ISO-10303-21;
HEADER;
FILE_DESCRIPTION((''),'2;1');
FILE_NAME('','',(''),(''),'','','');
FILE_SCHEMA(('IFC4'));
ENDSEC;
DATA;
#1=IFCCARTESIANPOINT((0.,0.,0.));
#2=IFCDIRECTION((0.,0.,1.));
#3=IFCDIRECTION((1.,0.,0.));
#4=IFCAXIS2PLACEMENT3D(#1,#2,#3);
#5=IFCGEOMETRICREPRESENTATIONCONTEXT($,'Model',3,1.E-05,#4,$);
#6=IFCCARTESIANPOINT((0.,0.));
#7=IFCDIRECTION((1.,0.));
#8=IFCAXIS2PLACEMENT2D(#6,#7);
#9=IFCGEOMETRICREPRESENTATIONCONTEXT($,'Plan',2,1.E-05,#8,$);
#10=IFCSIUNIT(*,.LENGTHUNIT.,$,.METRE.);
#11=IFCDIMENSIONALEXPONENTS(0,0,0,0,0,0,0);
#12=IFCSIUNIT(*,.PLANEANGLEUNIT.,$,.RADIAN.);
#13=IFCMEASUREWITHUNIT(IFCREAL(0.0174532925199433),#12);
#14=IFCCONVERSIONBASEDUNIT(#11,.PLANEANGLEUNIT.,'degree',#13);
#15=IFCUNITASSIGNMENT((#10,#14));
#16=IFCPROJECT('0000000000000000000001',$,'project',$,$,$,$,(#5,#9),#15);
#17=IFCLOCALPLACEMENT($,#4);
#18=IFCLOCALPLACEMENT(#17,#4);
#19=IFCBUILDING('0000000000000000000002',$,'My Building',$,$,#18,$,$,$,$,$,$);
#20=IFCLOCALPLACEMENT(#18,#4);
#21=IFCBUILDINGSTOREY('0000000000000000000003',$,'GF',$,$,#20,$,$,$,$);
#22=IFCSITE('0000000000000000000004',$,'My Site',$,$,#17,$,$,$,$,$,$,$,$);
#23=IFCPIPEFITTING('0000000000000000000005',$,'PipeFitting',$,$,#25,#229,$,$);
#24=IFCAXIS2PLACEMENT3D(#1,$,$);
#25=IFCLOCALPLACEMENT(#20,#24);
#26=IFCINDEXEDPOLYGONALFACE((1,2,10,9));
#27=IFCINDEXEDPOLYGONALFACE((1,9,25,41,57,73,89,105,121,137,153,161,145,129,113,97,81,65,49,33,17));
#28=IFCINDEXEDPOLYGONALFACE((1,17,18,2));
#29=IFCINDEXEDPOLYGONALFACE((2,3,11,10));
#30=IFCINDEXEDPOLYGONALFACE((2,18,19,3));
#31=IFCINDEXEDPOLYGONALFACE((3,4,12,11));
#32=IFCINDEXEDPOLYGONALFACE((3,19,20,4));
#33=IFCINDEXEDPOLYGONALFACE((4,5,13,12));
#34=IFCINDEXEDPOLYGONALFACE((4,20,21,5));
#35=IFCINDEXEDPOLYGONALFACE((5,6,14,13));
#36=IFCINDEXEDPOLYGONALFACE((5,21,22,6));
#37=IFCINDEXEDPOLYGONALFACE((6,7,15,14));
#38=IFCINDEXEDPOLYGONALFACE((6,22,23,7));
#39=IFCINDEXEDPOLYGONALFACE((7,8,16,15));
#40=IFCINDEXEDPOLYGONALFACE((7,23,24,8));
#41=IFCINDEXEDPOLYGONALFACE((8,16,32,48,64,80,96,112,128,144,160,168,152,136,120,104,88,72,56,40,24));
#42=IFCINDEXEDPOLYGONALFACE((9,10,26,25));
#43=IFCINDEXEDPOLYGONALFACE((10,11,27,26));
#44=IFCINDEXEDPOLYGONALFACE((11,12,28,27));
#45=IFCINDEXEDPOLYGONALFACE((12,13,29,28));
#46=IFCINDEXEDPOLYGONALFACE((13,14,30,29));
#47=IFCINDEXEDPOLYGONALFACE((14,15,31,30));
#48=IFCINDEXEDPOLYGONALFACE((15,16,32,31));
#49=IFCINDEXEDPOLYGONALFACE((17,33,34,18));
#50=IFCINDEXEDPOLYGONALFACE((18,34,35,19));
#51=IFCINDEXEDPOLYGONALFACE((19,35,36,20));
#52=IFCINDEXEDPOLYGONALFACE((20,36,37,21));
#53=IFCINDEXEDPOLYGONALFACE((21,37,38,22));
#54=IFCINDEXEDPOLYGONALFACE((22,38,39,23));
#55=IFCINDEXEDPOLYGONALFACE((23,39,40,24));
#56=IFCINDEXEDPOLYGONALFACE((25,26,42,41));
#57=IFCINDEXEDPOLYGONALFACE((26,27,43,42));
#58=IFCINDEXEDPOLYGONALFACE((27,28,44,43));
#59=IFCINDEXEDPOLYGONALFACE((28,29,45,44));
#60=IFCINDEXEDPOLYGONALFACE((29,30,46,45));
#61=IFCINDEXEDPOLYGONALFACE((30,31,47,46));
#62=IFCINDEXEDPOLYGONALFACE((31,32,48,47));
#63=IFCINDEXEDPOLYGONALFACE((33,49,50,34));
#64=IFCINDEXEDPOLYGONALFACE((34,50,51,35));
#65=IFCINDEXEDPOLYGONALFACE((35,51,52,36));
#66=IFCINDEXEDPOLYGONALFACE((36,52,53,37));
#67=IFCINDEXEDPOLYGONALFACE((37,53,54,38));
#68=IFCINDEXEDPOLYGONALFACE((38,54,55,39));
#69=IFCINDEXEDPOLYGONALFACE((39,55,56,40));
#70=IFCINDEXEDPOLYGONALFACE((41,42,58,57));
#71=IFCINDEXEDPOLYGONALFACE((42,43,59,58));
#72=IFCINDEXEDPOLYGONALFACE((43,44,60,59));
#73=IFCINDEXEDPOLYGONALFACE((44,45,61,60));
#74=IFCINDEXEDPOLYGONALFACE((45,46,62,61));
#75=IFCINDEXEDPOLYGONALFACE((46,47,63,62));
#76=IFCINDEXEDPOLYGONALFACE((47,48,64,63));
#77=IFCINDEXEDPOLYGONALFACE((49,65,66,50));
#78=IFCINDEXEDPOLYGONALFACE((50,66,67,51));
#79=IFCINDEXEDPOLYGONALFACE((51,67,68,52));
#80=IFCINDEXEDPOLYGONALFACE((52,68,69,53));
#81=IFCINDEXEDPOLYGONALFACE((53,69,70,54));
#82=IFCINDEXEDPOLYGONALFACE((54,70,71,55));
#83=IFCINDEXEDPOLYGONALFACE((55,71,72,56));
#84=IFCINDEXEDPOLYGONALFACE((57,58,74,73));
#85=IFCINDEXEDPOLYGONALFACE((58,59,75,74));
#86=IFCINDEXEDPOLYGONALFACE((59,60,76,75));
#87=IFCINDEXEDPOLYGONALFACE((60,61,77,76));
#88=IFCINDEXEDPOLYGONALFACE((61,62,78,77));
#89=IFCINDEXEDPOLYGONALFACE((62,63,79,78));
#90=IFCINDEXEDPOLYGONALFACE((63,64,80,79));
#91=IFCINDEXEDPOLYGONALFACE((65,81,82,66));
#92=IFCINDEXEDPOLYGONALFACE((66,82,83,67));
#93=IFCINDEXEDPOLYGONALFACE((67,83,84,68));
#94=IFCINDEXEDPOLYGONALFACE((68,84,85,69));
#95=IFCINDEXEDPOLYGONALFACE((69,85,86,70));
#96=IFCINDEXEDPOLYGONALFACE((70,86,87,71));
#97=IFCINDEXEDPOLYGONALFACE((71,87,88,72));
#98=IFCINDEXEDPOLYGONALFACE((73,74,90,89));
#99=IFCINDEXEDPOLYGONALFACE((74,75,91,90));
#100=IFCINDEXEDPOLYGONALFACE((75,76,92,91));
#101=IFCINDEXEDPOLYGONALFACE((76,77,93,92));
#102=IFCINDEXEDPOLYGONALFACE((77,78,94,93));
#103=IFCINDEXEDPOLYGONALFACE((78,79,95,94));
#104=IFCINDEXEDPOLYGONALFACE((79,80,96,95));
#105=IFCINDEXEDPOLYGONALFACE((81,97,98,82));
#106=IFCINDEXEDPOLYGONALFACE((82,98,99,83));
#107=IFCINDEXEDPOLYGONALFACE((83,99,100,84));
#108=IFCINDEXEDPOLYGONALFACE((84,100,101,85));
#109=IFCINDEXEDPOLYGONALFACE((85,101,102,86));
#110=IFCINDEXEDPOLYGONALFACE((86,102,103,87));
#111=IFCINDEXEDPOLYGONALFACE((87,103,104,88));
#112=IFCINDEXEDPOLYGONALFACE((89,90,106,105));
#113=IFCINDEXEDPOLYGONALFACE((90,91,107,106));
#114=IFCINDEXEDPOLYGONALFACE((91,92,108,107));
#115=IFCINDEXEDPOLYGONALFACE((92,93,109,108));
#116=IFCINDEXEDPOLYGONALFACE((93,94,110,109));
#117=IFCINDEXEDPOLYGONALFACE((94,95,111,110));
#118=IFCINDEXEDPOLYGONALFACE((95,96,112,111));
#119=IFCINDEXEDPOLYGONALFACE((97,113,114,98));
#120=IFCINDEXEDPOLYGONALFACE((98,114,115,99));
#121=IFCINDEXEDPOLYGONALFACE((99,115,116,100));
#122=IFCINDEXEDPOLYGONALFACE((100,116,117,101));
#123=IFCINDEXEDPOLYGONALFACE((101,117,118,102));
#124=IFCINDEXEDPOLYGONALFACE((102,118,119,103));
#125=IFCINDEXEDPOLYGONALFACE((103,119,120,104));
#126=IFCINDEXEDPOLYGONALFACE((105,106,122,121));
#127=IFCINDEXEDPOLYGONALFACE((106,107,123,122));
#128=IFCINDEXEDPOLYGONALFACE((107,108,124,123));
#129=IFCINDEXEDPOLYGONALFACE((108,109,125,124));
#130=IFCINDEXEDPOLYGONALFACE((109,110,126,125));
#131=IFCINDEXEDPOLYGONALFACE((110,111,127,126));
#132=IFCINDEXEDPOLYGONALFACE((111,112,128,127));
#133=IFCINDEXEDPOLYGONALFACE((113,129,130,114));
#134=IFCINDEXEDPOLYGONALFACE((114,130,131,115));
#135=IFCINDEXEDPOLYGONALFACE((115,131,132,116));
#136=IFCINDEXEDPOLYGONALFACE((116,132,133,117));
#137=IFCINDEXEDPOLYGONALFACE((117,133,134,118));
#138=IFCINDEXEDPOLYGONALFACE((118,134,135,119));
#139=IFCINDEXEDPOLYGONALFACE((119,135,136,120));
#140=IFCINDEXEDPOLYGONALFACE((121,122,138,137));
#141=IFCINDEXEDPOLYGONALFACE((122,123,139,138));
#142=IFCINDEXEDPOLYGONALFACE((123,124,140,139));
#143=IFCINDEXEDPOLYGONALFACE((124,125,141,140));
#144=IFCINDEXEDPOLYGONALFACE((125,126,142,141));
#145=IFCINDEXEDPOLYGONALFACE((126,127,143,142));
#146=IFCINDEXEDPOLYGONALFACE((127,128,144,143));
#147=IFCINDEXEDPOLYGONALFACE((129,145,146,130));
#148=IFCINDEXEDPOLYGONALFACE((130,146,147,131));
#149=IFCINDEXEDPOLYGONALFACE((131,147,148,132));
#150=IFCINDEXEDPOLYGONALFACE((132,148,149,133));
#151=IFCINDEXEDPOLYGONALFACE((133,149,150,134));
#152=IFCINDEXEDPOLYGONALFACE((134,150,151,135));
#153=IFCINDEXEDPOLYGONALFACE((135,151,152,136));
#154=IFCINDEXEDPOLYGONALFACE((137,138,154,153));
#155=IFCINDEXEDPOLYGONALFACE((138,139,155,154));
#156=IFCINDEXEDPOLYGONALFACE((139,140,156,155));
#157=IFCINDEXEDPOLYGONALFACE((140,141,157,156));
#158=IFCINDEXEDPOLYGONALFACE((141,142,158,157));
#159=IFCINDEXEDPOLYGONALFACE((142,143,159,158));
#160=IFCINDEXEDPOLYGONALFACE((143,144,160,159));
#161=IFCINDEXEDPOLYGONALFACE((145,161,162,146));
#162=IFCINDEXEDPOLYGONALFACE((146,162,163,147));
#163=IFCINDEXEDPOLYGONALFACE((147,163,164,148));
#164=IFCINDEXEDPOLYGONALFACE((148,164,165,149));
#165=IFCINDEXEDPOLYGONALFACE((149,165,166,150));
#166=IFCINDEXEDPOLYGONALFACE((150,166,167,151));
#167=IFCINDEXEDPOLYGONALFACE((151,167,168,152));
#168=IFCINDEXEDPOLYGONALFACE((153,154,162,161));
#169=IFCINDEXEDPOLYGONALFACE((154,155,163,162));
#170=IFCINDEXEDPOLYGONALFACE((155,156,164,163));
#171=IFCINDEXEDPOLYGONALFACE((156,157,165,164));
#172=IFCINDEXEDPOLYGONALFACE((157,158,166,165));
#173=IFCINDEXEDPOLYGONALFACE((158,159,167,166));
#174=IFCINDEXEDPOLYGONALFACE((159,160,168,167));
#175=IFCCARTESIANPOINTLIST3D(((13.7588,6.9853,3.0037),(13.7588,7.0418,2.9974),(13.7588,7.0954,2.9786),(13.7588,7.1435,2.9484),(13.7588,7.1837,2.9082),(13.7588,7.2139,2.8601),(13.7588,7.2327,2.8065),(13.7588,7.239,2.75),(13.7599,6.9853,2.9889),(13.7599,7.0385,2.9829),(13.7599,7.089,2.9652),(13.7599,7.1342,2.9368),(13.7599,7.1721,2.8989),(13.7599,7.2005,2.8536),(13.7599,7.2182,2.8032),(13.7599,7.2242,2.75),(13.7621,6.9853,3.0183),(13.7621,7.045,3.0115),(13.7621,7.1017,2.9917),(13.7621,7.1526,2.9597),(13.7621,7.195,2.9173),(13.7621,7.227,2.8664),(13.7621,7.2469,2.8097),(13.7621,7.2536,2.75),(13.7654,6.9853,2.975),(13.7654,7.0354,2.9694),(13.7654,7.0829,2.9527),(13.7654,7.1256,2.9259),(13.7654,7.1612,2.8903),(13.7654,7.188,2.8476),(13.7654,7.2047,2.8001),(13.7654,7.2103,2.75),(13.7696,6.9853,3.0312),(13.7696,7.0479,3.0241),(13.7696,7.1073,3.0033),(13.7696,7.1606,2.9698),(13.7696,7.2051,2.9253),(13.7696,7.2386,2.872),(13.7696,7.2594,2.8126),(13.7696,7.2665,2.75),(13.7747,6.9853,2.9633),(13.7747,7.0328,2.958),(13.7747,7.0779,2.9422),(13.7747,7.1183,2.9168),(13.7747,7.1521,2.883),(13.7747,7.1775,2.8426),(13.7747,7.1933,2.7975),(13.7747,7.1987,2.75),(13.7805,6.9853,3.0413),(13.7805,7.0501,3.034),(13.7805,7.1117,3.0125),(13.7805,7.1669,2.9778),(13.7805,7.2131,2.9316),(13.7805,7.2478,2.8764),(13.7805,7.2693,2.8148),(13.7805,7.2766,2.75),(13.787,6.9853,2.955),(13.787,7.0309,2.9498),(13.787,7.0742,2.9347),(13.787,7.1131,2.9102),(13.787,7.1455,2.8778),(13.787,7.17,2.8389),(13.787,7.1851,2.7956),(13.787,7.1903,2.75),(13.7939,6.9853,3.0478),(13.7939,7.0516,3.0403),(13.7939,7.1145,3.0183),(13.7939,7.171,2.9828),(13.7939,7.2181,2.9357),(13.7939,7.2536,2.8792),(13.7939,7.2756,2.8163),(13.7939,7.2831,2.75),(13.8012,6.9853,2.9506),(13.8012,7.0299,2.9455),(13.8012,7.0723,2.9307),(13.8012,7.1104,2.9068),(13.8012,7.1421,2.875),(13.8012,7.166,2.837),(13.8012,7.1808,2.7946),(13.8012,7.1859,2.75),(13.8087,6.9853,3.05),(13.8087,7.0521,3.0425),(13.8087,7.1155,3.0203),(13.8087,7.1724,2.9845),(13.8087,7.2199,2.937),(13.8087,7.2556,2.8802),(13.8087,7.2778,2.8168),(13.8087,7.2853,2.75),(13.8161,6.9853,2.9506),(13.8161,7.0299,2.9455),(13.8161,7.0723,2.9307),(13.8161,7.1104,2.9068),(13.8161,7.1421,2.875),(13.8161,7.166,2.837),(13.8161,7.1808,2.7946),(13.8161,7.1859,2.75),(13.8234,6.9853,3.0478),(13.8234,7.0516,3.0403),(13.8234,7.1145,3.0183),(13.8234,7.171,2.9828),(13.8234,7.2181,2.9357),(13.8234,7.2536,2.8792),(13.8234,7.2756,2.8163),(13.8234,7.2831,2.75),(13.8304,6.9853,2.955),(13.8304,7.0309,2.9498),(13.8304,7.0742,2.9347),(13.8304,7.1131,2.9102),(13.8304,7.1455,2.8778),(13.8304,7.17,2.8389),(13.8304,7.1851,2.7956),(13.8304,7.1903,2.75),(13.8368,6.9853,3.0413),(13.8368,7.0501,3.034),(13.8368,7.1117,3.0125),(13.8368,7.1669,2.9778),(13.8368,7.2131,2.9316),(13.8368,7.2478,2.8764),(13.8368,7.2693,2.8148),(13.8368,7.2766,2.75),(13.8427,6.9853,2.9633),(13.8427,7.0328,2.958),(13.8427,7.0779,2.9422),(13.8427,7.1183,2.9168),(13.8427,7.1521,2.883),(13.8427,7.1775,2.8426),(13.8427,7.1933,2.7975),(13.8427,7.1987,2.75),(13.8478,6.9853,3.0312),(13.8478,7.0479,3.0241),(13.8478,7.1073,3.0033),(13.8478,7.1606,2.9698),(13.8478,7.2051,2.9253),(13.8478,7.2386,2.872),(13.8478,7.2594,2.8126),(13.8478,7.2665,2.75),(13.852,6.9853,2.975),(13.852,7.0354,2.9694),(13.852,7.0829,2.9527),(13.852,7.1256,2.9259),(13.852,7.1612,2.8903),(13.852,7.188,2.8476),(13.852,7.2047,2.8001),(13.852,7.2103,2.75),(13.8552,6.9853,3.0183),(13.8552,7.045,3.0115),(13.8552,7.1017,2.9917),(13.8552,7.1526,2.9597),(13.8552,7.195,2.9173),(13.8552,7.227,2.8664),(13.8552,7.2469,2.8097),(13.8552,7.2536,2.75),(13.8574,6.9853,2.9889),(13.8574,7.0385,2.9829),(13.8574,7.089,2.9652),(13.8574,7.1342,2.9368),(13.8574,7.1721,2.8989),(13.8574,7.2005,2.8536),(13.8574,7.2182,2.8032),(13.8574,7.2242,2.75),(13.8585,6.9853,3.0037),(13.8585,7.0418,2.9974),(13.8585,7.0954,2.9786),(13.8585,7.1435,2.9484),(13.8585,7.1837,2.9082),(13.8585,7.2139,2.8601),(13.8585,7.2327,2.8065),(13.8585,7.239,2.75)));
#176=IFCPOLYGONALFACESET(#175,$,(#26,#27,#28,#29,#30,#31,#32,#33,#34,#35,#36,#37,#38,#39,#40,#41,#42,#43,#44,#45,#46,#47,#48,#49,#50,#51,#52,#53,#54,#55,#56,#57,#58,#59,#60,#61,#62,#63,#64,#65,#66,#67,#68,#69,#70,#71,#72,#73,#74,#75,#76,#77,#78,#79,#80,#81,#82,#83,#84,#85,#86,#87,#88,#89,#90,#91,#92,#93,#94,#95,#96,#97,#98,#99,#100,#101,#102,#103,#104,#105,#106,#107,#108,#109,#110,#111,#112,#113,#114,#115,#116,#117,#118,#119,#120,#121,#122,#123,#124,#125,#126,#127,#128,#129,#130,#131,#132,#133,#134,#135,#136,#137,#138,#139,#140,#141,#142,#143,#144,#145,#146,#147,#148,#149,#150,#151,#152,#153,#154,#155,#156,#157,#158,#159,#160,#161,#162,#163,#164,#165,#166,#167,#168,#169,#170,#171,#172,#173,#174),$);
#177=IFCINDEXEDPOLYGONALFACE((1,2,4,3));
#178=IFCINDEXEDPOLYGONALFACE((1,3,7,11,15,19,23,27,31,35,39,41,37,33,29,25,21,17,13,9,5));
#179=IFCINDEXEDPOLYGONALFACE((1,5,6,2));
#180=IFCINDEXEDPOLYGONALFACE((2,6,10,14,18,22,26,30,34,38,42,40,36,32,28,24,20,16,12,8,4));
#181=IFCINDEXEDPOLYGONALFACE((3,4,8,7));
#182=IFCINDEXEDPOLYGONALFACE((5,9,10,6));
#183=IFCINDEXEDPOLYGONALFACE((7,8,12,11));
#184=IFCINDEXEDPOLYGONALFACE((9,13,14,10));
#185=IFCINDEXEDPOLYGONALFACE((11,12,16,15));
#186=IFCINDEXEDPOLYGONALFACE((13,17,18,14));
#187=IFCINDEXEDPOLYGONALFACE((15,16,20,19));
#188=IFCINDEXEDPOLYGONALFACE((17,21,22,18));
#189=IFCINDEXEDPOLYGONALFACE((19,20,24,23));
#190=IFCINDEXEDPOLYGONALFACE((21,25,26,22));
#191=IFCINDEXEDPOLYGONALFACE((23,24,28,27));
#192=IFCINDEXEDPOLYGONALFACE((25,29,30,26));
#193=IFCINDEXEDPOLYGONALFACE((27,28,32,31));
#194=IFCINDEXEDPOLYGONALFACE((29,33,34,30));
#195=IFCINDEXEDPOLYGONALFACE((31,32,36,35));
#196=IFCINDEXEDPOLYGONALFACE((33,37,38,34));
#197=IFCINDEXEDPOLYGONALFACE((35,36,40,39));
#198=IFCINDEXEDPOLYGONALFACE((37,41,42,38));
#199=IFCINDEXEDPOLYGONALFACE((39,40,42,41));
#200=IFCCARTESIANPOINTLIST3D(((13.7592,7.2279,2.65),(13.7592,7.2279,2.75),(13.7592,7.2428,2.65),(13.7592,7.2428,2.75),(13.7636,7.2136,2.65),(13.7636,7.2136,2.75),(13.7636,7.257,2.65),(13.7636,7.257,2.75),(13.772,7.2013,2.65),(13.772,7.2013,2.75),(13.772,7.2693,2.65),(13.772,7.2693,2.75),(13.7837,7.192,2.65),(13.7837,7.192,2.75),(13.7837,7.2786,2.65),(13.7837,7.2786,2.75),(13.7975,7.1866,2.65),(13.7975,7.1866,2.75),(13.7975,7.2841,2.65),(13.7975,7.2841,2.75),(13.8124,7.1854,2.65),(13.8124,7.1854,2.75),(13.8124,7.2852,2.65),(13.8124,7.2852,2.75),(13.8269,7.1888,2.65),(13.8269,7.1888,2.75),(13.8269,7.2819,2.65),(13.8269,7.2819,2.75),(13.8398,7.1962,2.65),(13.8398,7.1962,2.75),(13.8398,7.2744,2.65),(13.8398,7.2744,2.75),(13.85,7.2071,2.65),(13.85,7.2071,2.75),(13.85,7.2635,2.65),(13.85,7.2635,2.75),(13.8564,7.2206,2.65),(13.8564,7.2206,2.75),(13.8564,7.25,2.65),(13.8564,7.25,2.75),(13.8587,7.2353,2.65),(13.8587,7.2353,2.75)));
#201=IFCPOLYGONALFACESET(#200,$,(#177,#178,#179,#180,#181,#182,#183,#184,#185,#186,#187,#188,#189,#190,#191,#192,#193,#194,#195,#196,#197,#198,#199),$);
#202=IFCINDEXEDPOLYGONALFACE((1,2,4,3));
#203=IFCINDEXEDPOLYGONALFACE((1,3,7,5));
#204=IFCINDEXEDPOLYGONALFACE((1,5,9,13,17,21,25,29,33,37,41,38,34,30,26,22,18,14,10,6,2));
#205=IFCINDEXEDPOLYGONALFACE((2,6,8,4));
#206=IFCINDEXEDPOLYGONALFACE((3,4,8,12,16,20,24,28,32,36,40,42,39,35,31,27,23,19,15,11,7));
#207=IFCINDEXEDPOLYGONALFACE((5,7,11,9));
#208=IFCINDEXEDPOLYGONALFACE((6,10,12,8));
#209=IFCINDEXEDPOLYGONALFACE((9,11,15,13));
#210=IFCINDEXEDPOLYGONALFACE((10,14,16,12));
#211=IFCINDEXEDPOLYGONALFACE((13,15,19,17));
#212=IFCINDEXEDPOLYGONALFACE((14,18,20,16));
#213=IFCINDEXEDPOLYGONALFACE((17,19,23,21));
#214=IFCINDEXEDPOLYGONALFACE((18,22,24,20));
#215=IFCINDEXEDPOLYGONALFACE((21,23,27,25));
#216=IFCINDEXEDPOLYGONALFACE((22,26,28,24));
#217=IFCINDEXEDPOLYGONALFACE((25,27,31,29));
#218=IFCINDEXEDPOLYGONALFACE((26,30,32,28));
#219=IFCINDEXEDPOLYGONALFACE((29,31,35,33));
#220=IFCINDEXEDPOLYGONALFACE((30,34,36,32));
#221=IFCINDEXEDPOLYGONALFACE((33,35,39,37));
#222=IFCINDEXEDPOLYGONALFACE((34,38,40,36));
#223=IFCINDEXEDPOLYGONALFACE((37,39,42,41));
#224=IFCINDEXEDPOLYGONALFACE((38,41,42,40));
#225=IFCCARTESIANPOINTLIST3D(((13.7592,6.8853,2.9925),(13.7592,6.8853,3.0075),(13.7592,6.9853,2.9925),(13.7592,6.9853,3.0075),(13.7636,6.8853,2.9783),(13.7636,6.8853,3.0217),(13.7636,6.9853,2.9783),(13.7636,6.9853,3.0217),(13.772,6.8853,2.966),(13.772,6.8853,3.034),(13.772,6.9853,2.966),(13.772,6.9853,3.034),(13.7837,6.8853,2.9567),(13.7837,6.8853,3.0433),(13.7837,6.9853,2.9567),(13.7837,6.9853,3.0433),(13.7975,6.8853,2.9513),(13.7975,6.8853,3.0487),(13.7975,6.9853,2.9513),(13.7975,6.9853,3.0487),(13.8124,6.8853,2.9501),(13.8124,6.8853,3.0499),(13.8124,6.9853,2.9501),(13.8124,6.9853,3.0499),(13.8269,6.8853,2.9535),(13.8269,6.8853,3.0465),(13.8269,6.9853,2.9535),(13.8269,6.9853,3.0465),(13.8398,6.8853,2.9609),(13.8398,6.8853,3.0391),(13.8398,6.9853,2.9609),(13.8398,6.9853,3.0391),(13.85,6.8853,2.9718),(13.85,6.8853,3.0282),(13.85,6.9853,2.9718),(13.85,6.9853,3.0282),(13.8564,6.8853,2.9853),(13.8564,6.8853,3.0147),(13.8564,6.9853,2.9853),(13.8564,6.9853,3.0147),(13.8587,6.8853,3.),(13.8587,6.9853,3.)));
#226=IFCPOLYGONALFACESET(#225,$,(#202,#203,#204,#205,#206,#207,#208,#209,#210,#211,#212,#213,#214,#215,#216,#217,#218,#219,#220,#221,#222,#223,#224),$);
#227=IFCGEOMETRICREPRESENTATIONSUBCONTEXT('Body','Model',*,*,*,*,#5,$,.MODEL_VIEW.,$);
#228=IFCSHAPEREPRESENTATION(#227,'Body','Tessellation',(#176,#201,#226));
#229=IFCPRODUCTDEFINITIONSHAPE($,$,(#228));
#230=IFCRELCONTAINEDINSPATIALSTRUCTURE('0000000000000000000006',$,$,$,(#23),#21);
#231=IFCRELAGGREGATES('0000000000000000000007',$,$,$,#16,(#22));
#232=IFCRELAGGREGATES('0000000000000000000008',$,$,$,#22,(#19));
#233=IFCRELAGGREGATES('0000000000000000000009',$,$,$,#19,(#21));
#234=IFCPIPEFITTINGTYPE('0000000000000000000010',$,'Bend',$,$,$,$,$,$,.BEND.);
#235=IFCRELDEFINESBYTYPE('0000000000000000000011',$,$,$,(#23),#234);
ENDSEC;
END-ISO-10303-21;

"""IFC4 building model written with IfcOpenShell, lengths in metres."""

from ifc_helpers import new_model, entity, si_unit, converted_unit, frame, origin_with_axes, origin_2d_with_axis, place, context, subcontext, project, spatial, circle, extrude, source, transform, mapped, type_object, type_shapes, element, save


model = new_model("IFC4")

# Units and contexts
model_context = context("Model", 3, precision=1e-05, world=origin_with_axes())
plan_context = context("Plan", 2, precision=1e-05, world=origin_2d_with_axis())
body_context_1 = subcontext(model_context, "Body", "Model", "MODEL_VIEW")
ifc_project = project(units=[si_unit("LENGTHUNIT", "METRE"), converted_unit("PLANEANGLEUNIT", "degree", entity("IfcReal", 0.0174532925199433), si_unit("PLANEANGLEUNIT", "RADIAN"), dimensions=[0, 0, 0, 0, 0, 0, 0])], contexts=[model_context, plan_context])

# Site, building, storey
site_placement = place(None, origin_with_axes())
site = spatial("IfcSite", under=ifc_project, at=site_placement, Name="My Site")
building_placement = place(site_placement, origin_with_axes())
building = spatial("IfcBuilding", under=site, at=building_placement, Name="My Building")
storey_placement = place(building_placement, origin_with_axes())
storey = spatial("IfcBuildingStorey", under=building, at=storey_placement, Name="GF")

# Pipe fitting
pipe_fitting_type = type_object("IfcPipeFittingType", Name="Bend", PredefinedType="BEND")
shared_shape_1 = source(origin_with_axes(), body_context_1, "Body", "SolidModel", [
    entity("IfcSweptDiskSolid", entity("IfcIndexedPolyCurve", entity("IfcCartesianPointList3D", [[0.0, 0.0, -0.1], [0.0, 0.0732, -0.2768], [0.0, 0.25, -0.35]]), [entity("IfcArcIndex", [1, 2, 3])]), 0.05),
    extrude(circle(Radius=0.05), origin_with_axes(), (0.0, 0.0, -1.0), 0.1),
    extrude(circle(Radius=0.05), frame((0.0, 0.25, -0.35), z_axis=(0.0, 1.0, 0.0), x_axis=(1.0, 0.0, 0.0)), (0.0, 0.0, 1.0), 0.1),
])
type_shapes(pipe_fitting_type, [shared_shape_1])
for number, where, z_axis, x_axis, name in (
    (1, (13.8087, 7.2353, 2.65), (0.0, 0.0, -1.0), (1.0, 0.0, 0.0), "PipeFitting"),
):
    element("IfcPipeFitting", number, at=place(storey_placement, frame(where, z_axis=z_axis, x_axis=x_axis)), inside=storey, type_object=pipe_fitting_type, Name=name, context=body_context_1, shape_type="MappedRepresentation", body=[
        mapped(shared_shape_1, transform((0.0, 0.0, 0.0), x_axis=(1.0, 0.0, 0.0), y_axis=(0.0, 1.0, 0.0), z_axis=(0.0, 0.0, 1.0), scale=1.0)),
    ])

save(model, "model.ifc")
